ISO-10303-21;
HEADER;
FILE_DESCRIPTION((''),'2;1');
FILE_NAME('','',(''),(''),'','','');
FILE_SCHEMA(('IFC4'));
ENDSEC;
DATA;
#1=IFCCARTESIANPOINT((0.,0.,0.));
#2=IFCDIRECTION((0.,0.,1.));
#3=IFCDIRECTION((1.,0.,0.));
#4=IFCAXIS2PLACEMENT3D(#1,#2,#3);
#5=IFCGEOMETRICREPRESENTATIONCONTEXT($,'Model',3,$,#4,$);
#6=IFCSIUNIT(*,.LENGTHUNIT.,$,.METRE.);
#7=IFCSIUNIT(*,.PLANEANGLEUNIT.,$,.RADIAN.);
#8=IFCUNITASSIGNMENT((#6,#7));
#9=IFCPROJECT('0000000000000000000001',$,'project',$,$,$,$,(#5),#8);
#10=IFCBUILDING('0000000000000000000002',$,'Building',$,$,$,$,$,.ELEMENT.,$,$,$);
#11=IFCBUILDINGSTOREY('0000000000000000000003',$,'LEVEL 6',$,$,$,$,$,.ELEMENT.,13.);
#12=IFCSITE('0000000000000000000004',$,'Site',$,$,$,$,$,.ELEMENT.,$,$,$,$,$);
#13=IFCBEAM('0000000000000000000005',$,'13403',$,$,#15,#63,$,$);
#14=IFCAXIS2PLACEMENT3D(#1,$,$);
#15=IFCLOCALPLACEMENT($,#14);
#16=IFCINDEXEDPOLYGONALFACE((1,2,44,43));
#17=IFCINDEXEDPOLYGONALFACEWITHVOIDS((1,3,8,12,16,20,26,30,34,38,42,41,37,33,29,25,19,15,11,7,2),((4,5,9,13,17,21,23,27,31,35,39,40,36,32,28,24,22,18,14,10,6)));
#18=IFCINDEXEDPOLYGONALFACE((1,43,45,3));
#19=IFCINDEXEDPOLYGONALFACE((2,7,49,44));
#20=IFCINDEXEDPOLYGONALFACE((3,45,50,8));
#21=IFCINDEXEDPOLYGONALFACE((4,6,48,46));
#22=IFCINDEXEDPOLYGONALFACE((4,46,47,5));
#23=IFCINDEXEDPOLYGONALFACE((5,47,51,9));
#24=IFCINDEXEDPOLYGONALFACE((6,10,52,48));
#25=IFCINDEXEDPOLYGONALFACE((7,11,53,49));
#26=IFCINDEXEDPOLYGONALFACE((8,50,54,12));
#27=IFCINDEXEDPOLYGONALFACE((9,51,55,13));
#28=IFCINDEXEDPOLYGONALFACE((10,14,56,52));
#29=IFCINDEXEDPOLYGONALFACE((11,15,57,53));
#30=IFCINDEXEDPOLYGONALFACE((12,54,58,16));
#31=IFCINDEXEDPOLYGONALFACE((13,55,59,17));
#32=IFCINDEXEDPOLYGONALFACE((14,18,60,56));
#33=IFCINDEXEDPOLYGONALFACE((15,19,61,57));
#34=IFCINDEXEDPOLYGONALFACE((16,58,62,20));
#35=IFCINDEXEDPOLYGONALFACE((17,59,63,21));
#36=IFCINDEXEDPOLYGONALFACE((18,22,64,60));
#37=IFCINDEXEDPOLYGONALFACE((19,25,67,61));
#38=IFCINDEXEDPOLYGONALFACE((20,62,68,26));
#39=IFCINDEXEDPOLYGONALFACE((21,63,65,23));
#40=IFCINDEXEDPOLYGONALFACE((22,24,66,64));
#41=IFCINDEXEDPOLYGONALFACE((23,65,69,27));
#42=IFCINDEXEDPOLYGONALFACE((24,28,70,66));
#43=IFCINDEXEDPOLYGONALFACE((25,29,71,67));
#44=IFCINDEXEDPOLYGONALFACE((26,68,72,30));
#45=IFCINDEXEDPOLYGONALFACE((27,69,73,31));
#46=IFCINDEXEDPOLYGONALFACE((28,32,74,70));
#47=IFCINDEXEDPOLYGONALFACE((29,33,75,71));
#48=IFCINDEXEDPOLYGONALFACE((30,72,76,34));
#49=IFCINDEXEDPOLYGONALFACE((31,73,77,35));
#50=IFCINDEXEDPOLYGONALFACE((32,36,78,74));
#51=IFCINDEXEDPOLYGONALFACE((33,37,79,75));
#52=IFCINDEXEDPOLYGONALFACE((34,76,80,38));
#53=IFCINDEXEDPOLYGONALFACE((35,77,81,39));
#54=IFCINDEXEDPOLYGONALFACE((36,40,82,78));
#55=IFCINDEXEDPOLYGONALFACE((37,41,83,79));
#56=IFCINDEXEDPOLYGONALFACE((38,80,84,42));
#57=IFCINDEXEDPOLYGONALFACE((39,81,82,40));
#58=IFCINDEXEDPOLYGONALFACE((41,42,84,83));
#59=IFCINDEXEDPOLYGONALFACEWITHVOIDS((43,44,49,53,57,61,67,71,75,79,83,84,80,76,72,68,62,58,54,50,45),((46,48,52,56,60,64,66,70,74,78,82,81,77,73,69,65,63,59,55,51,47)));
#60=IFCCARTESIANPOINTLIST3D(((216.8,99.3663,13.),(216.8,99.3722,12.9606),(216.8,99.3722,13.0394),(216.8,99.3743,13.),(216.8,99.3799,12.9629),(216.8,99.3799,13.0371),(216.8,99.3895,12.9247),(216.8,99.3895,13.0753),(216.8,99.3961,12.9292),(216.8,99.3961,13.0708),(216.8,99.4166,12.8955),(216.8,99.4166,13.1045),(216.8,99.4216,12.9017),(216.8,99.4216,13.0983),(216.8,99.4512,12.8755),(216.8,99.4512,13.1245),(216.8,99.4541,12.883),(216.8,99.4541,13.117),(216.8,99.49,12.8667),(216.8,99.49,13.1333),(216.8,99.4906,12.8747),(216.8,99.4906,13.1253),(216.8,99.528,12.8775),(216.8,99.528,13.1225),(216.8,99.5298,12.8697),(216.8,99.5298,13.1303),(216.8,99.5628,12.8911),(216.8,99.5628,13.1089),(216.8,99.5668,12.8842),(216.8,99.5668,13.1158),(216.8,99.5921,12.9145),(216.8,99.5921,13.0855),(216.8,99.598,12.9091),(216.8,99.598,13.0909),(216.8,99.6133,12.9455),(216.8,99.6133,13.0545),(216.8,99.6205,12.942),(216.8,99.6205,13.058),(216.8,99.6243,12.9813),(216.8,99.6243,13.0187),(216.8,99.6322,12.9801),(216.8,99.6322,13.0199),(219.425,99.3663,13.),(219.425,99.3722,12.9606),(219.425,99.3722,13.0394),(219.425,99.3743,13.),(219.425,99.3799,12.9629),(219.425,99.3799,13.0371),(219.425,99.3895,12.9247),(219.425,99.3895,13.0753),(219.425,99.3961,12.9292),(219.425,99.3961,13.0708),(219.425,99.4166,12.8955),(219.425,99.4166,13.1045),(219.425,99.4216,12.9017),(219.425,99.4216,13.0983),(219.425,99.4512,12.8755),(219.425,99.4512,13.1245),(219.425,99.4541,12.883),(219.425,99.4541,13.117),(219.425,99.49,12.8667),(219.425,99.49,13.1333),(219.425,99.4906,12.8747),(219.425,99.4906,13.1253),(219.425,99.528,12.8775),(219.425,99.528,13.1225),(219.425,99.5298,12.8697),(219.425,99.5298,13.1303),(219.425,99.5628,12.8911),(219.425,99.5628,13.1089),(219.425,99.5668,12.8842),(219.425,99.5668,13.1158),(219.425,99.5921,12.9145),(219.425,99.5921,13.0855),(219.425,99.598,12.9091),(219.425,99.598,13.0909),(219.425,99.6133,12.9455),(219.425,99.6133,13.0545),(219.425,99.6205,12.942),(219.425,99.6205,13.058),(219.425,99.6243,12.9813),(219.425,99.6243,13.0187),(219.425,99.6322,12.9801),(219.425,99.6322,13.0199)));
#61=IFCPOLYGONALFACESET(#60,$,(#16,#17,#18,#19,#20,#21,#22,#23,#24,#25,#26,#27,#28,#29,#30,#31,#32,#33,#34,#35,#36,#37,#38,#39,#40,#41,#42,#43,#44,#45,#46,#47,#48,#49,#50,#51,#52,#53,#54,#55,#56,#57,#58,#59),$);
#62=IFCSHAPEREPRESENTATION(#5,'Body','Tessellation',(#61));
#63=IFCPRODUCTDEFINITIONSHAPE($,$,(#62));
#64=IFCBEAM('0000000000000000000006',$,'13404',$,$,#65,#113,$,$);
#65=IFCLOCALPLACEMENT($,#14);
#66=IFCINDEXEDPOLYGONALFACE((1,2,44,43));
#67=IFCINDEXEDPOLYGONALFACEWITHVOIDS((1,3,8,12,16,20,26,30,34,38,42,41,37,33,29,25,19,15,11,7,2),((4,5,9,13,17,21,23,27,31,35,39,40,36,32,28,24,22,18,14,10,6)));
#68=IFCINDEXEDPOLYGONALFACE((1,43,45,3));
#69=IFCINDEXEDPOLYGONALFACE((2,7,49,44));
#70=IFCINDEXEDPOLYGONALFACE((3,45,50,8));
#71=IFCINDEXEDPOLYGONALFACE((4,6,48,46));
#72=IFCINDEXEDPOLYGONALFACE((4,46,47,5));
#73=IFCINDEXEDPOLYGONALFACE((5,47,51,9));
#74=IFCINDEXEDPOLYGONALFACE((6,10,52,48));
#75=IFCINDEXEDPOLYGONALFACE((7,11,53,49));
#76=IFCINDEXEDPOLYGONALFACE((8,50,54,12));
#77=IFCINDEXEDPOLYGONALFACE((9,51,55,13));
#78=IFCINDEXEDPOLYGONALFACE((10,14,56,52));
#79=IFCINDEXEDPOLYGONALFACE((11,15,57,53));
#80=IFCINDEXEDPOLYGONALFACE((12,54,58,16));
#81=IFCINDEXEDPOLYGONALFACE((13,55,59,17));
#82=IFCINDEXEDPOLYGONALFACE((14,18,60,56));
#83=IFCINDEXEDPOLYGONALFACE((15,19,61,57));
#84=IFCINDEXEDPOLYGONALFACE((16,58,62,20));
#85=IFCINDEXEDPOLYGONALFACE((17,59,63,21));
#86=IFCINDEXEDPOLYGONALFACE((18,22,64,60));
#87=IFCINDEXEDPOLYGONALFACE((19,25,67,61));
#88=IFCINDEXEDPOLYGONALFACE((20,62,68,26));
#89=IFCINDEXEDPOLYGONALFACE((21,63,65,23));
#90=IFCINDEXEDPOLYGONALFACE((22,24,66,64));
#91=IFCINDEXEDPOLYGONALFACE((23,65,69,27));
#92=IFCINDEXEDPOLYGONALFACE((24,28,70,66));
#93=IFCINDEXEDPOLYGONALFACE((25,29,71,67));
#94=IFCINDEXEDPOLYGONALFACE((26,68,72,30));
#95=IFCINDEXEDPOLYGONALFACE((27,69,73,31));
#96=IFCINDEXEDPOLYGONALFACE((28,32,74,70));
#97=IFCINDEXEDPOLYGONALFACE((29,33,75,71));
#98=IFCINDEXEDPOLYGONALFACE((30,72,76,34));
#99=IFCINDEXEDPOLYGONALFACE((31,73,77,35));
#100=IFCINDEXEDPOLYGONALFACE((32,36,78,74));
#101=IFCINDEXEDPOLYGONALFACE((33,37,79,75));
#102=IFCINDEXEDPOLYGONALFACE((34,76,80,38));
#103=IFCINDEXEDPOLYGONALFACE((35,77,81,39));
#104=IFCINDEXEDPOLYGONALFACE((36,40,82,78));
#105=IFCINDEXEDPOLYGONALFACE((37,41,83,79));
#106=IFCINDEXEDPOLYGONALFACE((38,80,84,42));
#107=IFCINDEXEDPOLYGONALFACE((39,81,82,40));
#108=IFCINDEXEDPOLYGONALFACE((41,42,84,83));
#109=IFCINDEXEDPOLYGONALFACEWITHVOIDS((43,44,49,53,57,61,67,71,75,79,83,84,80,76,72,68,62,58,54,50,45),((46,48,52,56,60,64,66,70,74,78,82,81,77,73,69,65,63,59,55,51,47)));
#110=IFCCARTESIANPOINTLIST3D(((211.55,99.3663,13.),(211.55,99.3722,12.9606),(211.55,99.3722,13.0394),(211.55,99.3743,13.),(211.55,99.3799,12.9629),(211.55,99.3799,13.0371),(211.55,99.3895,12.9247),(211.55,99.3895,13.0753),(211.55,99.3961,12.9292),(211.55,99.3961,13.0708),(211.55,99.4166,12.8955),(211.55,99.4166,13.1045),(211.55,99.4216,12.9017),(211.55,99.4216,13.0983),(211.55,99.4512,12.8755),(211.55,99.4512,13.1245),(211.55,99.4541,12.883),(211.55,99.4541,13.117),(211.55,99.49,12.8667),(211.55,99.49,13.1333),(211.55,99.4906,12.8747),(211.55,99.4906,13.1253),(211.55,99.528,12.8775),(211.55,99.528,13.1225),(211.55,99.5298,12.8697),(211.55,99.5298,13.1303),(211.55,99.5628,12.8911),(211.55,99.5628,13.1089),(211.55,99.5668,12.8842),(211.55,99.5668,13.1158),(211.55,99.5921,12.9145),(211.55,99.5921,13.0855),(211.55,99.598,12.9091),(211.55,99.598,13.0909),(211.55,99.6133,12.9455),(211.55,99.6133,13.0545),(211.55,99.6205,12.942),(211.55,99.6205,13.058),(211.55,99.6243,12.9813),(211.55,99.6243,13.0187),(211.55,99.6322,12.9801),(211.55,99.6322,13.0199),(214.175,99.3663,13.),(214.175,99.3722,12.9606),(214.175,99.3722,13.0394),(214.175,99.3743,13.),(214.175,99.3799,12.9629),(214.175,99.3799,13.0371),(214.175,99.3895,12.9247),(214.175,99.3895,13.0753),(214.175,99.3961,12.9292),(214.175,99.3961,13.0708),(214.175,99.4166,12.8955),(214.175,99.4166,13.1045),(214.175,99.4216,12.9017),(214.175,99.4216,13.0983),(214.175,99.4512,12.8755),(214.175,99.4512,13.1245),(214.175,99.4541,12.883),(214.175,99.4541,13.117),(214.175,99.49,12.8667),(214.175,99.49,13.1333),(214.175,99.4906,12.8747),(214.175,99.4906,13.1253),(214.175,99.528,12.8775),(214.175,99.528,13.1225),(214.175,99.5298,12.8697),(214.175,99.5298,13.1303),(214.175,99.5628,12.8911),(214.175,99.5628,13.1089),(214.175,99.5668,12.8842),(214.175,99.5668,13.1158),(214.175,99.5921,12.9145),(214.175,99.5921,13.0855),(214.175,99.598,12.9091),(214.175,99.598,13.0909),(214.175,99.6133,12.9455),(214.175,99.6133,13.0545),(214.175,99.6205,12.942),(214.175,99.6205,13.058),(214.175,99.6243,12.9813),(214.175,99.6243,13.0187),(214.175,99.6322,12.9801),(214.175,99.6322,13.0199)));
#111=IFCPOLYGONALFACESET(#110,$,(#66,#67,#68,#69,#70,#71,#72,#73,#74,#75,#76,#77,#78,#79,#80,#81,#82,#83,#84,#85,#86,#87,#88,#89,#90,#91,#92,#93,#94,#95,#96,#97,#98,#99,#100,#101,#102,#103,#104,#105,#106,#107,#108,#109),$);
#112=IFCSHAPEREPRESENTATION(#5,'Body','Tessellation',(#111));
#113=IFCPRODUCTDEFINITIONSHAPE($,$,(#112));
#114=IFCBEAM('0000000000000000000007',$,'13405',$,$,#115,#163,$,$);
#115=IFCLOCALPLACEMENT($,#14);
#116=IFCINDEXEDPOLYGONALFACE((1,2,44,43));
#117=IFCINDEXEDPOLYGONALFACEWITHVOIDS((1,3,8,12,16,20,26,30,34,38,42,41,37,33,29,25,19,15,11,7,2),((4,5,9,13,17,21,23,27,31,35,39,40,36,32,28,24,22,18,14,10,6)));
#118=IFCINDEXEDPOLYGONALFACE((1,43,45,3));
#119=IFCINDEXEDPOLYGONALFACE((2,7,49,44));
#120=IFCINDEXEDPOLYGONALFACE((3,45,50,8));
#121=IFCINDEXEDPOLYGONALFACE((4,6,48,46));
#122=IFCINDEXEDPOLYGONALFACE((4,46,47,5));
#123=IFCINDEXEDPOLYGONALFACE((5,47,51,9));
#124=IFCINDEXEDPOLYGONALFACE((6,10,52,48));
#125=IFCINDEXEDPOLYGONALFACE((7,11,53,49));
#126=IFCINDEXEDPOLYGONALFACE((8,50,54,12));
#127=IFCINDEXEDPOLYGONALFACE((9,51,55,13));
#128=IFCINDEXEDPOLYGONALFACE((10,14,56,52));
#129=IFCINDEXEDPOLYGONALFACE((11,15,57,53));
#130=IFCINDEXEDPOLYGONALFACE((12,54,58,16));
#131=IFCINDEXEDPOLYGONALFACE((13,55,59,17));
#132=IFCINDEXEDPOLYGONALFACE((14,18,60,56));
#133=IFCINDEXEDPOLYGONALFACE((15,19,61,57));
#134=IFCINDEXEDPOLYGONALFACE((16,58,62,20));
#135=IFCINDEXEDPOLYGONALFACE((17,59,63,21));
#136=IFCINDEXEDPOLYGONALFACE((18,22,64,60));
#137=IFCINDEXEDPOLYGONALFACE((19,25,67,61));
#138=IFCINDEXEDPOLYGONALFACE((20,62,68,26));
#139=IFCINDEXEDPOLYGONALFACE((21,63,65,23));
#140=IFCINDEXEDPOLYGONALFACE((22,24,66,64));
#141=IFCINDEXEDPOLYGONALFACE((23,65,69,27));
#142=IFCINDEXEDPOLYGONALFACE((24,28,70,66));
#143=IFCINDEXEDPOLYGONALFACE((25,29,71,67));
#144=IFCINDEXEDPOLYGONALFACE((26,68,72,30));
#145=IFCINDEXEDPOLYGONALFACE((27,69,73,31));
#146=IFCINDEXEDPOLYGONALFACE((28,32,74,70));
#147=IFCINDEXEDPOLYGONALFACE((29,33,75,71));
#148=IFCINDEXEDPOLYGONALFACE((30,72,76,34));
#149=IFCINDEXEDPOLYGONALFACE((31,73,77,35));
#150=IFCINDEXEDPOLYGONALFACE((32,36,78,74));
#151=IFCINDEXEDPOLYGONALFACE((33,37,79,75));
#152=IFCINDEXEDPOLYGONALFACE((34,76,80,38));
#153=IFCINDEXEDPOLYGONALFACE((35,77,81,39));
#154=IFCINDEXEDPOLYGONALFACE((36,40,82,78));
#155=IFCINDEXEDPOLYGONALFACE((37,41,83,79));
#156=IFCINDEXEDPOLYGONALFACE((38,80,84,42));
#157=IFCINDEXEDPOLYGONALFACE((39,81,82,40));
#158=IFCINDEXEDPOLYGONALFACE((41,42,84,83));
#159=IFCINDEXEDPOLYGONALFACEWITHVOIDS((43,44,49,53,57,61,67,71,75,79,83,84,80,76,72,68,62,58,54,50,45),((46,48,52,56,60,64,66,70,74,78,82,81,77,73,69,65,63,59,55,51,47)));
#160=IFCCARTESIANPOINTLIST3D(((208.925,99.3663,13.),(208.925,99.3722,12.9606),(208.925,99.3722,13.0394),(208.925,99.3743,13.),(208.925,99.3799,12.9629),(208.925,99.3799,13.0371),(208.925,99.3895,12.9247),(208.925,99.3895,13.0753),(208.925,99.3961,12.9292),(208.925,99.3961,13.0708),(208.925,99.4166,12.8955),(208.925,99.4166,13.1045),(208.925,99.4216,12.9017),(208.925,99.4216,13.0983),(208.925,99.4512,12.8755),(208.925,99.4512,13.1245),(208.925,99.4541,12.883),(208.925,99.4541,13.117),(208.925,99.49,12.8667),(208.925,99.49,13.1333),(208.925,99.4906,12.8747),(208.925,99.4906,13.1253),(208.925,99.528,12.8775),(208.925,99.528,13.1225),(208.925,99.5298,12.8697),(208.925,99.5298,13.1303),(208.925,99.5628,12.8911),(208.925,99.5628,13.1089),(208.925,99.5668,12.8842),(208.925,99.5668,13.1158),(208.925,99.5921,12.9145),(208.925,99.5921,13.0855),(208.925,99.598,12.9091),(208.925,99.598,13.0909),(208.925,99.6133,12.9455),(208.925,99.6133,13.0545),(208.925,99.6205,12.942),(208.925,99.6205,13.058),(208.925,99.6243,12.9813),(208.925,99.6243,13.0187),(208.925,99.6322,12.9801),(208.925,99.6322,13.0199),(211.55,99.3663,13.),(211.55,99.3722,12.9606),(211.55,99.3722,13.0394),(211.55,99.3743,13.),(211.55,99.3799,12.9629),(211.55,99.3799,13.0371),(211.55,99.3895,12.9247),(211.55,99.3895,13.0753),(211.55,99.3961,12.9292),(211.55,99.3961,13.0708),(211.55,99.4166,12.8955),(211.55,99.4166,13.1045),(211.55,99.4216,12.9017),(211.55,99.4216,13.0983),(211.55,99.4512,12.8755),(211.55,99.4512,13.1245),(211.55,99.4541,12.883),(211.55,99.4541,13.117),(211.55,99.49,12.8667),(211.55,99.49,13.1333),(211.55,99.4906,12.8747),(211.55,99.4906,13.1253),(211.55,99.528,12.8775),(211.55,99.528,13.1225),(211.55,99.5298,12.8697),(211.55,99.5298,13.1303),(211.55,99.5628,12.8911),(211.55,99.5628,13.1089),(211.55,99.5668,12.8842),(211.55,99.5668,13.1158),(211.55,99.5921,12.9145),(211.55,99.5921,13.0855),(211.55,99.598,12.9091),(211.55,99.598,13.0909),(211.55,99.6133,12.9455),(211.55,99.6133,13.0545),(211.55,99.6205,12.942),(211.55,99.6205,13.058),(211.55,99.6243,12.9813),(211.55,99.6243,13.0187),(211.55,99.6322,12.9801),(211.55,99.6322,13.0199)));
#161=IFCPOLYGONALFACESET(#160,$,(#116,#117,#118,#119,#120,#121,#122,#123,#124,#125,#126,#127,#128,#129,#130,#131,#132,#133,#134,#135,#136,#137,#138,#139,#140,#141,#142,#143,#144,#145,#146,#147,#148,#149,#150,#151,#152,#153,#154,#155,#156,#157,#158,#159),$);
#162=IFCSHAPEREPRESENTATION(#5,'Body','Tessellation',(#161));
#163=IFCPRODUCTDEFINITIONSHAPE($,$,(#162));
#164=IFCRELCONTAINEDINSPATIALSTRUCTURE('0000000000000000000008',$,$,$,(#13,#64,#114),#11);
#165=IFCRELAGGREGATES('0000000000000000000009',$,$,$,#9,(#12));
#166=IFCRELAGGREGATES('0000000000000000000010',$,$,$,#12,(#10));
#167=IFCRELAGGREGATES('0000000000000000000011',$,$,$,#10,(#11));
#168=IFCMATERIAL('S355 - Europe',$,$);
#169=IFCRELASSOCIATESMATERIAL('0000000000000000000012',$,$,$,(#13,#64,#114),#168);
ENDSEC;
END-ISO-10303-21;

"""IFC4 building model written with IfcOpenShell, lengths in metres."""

from ifc_helpers import new_model, si_unit, frame, origin_with_axes, origin_2d_with_axis, place, context, project, spatial, hollow_circle, extrude, material, material_profile, profile_set, profile_usage, element, save


model = new_model("IFC4")

# Units and contexts
model_context = context("Model", 3, world=origin_with_axes())
ifc_project = project(units=[si_unit("LENGTHUNIT", "METRE"), si_unit("PLANEANGLEUNIT", "RADIAN")], contexts=[model_context])

# Site, building, storey
site = spatial("IfcSite", under=ifc_project, Name="Site", CompositionType="ELEMENT")
building = spatial("IfcBuilding", under=site, Name="Building", CompositionType="ELEMENT")
storey = spatial("IfcBuildingStorey", under=building, Name="LEVEL 6", CompositionType="ELEMENT", Elevation=13.0)

# Shared definitions
ifc_material = material(Name="S355 - Europe")

# Beams
ifc_material_profile_1 = material_profile(ifc_material, hollow_circle(Radius=0.1337, WallThickness=0.008, at=origin_2d_with_axis()))
ifc_profile_set_1 = profile_set([ifc_material_profile_1])
ifc_profile_usage_1 = profile_usage(ifc_profile_set_1, cardinal=10)
beam_1_placement = place(None, frame((219.425, 99.5, 13.0), z_axis=(-1.0, 0.0, 0.0), x_axis=(0.0, -1.0, 0.0)))
element("IfcBeam", 1, at=beam_1_placement, inside=storey, material=ifc_profile_usage_1, Name="13403", context=model_context, shape_type="SweptSolid", body=[
    extrude(hollow_circle(Radius=0.1337, WallThickness=0.008, at=origin_2d_with_axis()), origin_with_axes(), (0.0, 0.0, 1.0), 2.625),
])
ifc_material_profile_2 = material_profile(ifc_material, hollow_circle(Radius=0.1337, WallThickness=0.008, at=origin_2d_with_axis()))
ifc_profile_set_2 = profile_set([ifc_material_profile_2])
ifc_profile_usage_2 = profile_usage(ifc_profile_set_2, cardinal=10)
beam_2_placement = place(None, frame((214.175, 99.5, 13.0), z_axis=(-1.0, 0.0, 0.0), x_axis=(0.0, -1.0, 0.0)))
element("IfcBeam", 2, at=beam_2_placement, inside=storey, material=ifc_profile_usage_2, Name="13404", context=model_context, shape_type="SweptSolid", body=[
    extrude(hollow_circle(Radius=0.1337, WallThickness=0.008, at=origin_2d_with_axis()), origin_with_axes(), (0.0, 0.0, 1.0), 2.625),
])
ifc_material_profile_3 = material_profile(ifc_material, hollow_circle(Radius=0.1337, WallThickness=0.008, at=origin_2d_with_axis()))
ifc_profile_set_3 = profile_set([ifc_material_profile_3])
ifc_profile_usage_3 = profile_usage(ifc_profile_set_3, cardinal=10)
beam_3_placement = place(None, frame((211.55, 99.5, 13.0), z_axis=(-1.0, 0.0, 0.0), x_axis=(0.0, -1.0, 0.0)))
element("IfcBeam", 3, at=beam_3_placement, inside=storey, material=ifc_profile_usage_3, Name="13405", context=model_context, shape_type="SweptSolid", body=[
    extrude(hollow_circle(Radius=0.1337, WallThickness=0.008, at=origin_2d_with_axis()), origin_with_axes(), (0.0, 0.0, 1.0), 2.625),
])

save(model, "model.ifc")
